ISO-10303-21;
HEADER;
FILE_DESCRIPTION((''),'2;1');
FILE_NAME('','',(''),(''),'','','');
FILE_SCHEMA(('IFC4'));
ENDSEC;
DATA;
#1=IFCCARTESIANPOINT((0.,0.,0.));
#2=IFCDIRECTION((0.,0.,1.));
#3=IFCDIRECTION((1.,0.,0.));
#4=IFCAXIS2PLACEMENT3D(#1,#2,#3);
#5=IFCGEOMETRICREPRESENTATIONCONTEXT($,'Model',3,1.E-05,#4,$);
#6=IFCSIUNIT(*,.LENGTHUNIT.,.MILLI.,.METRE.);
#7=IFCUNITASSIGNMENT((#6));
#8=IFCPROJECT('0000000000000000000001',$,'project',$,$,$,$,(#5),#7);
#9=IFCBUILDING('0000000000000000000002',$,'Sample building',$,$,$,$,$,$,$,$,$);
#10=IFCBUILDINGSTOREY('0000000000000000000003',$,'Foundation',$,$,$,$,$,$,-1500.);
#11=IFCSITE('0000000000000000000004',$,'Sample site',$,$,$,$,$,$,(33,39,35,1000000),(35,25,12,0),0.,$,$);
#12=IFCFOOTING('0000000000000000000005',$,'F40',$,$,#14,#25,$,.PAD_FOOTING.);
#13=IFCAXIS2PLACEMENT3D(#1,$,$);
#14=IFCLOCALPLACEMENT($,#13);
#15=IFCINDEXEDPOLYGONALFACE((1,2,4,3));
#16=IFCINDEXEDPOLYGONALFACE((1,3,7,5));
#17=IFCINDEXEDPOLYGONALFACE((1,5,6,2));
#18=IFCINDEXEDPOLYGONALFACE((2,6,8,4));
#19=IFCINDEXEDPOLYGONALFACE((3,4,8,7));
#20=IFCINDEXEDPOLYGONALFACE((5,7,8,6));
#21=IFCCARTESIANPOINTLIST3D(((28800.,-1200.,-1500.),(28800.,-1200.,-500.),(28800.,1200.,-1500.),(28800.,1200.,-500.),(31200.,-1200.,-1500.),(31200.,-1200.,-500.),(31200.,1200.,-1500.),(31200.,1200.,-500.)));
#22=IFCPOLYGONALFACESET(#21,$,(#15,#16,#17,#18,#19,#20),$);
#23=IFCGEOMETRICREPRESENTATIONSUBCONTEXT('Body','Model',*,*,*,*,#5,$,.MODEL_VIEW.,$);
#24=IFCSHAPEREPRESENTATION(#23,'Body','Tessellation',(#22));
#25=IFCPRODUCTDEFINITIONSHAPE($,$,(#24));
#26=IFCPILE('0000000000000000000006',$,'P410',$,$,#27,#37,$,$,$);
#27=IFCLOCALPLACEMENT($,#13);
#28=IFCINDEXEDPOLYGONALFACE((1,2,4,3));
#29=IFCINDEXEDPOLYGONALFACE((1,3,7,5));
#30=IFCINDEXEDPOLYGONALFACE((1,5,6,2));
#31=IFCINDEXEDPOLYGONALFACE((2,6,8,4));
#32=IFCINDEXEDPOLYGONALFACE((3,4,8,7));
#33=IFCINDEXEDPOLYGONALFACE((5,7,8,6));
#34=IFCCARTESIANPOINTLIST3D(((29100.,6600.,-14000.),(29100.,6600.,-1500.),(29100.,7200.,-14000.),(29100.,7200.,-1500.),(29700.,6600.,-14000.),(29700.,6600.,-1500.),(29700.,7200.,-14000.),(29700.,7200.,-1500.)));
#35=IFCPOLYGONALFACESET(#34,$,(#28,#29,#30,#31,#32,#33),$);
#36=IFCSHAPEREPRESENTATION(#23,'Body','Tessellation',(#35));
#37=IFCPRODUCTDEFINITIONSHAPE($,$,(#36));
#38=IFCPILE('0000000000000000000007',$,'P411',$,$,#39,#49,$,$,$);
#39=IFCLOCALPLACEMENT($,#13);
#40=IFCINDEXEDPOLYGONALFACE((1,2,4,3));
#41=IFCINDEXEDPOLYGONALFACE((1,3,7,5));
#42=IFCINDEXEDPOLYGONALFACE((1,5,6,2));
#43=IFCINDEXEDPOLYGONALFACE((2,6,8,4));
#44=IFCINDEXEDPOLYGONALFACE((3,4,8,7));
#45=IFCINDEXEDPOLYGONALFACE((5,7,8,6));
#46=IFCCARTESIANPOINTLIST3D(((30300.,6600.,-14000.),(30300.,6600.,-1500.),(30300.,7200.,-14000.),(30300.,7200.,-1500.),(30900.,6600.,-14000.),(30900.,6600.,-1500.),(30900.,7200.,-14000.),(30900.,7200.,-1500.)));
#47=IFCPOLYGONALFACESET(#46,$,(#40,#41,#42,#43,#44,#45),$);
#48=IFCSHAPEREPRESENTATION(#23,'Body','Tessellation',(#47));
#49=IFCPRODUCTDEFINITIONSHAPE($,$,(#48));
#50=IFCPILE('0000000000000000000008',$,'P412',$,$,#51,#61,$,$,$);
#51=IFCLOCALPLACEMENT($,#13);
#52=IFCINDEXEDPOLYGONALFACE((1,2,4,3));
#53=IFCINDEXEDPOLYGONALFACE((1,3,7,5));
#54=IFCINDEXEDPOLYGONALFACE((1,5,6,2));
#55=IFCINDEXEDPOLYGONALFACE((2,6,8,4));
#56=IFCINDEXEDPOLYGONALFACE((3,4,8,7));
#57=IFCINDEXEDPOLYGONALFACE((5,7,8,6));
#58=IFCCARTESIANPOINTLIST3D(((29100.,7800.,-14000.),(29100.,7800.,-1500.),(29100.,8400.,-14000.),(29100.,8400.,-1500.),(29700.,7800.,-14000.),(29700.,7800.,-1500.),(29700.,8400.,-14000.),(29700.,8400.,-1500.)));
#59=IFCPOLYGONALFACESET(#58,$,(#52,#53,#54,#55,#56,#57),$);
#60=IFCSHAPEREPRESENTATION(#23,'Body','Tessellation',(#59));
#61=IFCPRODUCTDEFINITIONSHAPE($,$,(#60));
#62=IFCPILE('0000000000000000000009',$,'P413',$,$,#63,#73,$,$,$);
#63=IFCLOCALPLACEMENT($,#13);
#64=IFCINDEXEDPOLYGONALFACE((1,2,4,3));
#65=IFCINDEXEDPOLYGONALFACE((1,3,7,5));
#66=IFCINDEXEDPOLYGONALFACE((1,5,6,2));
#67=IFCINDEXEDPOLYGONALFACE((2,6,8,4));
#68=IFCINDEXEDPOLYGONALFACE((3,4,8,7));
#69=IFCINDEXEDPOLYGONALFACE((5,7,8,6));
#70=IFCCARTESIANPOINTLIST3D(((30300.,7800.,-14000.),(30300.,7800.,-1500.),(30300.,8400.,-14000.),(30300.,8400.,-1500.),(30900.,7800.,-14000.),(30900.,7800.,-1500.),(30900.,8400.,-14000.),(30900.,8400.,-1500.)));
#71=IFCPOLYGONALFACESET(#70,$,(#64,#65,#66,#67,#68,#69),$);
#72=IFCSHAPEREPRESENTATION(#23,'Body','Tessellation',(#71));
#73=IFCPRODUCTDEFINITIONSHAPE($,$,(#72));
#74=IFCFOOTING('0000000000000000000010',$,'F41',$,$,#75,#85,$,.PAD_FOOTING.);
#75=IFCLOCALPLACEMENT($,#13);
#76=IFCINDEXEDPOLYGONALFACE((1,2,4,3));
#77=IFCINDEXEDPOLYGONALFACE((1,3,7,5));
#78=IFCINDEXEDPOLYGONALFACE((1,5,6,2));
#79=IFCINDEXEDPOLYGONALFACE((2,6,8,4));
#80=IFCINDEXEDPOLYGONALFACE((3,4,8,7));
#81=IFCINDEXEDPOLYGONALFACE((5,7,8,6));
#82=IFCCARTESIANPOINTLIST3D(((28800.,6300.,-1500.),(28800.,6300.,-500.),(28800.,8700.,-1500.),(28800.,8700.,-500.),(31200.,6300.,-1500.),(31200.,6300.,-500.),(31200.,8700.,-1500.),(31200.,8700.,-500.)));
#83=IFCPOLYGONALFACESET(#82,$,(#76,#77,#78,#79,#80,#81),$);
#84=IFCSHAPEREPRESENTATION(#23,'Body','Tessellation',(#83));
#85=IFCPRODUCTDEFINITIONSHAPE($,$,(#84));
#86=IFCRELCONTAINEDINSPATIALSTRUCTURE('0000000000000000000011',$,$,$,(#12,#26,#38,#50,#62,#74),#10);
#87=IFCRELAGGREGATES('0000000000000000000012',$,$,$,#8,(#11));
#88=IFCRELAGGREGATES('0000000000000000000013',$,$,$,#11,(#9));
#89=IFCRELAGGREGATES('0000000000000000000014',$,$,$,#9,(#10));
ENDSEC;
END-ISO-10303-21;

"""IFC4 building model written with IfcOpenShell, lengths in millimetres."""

from ifc_helpers import new_model, si_unit, frame, origin_with_axes, place, context, subcontext, project, spatial, indexed_curve, outline, extrude, element, save


model = new_model("IFC4")

# Units and contexts
model_context = context("Model", 3, precision=1e-05, world=origin_with_axes())
body_context = subcontext(model_context, "Body", "Model", "MODEL_VIEW")
ifc_project = project(units=[si_unit("LENGTHUNIT", "METRE", prefix="MILLI")], contexts=[model_context])

# Site, building, storey
site = spatial("IfcSite", under=ifc_project, Name="Sample site", RefLatitude=(33, 39, 35, 1000000), RefLongitude=(35, 25, 12, 0), RefElevation=0.0)
building = spatial("IfcBuilding", under=site, Name="Sample building")
storey = spatial("IfcBuildingStorey", under=building, Name="Foundation", Elevation=-1500.0)

# Footing
footing_1_placement = place(None, frame((28800.0, -1200.0, -1500.0), z_axis=(0.0, 0.0, 1.0), x_axis=(1.0, 0.0, 0.0)))
element("IfcFooting", 1, at=footing_1_placement, inside=storey, Name="F40", PredefinedType="PAD_FOOTING", context=body_context, shape_type="SweptSolid", body=[
    extrude(outline(indexed_curve([(0.0, 0.0), (0.0, 2400.0), (2400.0, 2400.0), (2400.0, 0.0), (0.0, 0.0)], self_intersect=False)), origin_with_axes(), (0.0, 0.0, 1.0), 1000.0),
])

# Piles
for number, where, z_axis, x_axis, name in (
    (2, (29100.0, 6600.0, -14000.0), (0.0, 0.0, 1.0), (1.0, 0.0, 0.0), "P410"),
    (3, (30300.0, 6600.0, -14000.0), (0.0, 0.0, 1.0), (1.0, 0.0, 0.0), "P411"),
    (4, (29100.0, 7800.0, -14000.0), (0.0, 0.0, 1.0), (1.0, 0.0, 0.0), "P412"),
    (5, (30300.0, 7800.0, -14000.0), (0.0, 0.0, 1.0), (1.0, 0.0, 0.0), "P413"),
):
    element("IfcPile", number, at=place(None, frame(where, z_axis=z_axis, x_axis=x_axis)), inside=storey, Name=name, context=body_context, shape_type="SweptSolid", body=[
        extrude(outline(indexed_curve([(0.0, 0.0), (0.0, 600.0), (600.0, 600.0), (600.0, 0.0), (0.0, 0.0)], self_intersect=False)), origin_with_axes(), (0.0, 0.0, 1.0), 12500.0),
    ])

# Footing
footing_2_placement = place(None, frame((28800.0, 6300.0, -1500.0), z_axis=(0.0, 0.0, 1.0), x_axis=(1.0, 0.0, 0.0)))
element("IfcFooting", 6, at=footing_2_placement, inside=storey, Name="F41", PredefinedType="PAD_FOOTING", context=body_context, shape_type="SweptSolid", body=[
    extrude(outline(indexed_curve([(0.0, 0.0), (0.0, 2400.0), (2400.0, 2400.0), (2400.0, 0.0), (0.0, 0.0)], self_intersect=False)), origin_with_axes(), (0.0, 0.0, 1.0), 1000.0),
])

save(model, "model.ifc")
